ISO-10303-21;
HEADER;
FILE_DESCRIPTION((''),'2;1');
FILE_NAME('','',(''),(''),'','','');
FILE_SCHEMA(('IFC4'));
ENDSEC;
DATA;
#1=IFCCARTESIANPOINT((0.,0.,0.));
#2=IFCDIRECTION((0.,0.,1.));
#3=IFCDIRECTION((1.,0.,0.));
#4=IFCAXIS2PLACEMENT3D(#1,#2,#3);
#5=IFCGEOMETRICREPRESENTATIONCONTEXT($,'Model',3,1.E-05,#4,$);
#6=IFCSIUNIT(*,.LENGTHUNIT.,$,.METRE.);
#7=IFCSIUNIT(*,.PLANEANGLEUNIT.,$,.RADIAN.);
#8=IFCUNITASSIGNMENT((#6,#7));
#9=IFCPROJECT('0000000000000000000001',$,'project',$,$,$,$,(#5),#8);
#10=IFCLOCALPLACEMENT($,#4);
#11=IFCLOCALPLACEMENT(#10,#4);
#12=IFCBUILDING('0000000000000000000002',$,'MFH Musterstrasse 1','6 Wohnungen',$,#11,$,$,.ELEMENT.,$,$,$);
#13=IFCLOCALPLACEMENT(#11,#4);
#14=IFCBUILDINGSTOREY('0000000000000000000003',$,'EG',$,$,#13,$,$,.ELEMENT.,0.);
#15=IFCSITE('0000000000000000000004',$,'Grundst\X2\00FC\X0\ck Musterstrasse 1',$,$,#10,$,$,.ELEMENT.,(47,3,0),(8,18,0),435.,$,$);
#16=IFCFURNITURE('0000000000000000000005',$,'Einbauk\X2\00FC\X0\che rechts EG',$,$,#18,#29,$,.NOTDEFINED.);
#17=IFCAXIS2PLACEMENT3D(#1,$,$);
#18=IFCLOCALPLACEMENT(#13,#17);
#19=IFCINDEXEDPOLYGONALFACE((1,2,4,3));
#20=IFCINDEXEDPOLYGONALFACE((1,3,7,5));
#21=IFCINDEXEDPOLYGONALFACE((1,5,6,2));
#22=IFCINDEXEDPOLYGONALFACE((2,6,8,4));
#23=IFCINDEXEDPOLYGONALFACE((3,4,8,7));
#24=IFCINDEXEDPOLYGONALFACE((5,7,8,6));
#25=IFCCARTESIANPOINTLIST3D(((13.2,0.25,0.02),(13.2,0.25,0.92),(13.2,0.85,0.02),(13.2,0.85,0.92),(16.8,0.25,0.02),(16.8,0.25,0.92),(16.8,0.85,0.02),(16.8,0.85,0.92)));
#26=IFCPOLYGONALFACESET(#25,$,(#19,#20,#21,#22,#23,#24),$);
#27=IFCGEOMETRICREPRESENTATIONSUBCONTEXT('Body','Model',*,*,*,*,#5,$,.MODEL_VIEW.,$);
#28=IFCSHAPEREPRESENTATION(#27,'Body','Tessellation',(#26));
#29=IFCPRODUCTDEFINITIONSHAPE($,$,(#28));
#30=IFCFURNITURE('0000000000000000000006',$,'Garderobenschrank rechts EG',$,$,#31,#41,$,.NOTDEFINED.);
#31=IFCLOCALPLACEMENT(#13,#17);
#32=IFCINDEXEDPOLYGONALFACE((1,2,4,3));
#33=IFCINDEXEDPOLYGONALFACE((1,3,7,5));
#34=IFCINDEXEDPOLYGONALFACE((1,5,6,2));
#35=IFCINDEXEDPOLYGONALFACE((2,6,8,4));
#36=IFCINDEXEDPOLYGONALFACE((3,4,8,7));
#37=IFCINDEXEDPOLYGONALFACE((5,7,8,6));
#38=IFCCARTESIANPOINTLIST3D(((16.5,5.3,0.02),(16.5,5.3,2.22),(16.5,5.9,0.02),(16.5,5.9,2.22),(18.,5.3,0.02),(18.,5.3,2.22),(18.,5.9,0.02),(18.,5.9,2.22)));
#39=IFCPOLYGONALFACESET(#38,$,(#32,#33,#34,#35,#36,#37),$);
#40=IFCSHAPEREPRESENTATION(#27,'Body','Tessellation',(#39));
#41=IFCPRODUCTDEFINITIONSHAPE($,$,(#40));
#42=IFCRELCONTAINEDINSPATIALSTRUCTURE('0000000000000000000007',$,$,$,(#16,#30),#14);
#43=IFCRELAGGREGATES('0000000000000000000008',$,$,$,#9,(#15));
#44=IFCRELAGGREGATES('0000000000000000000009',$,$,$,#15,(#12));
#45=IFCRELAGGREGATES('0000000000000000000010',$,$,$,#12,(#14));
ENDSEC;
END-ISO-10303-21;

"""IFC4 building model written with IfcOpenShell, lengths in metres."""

from ifc_helpers import new_model, si_unit, frame, frame_2d, origin_with_axes, place, context, subcontext, project, spatial, rectangle, extrude, element, save


model = new_model("IFC4")

# Units and contexts
model_context = context("Model", 3, precision=1e-05, world=origin_with_axes())
body_context = subcontext(model_context, "Body", "Model", "MODEL_VIEW")
ifc_project = project(units=[si_unit("LENGTHUNIT", "METRE"), si_unit("PLANEANGLEUNIT", "RADIAN")], contexts=[model_context])

# Site, building, storey
site_placement = place(None, origin_with_axes())
site = spatial("IfcSite", under=ifc_project, at=site_placement, Name="Grundstück Musterstrasse 1", CompositionType="ELEMENT", RefLatitude=(47, 3, 0), RefLongitude=(8, 18, 0), RefElevation=435.0)
building_placement = place(site_placement, origin_with_axes())
building = spatial("IfcBuilding", under=site, at=building_placement, Name="MFH Musterstrasse 1", Description="6 Wohnungen", CompositionType="ELEMENT")
storey_placement = place(building_placement, origin_with_axes())
storey = spatial("IfcBuildingStorey", under=building, at=storey_placement, Name="EG", CompositionType="ELEMENT", Elevation=0.0)

# Furniture
furniture_1_placement = place(storey_placement, origin_with_axes())
element("IfcFurniture", 1, at=furniture_1_placement, inside=storey, Name="Einbauküche rechts EG", PredefinedType="NOTDEFINED", context=body_context, shape_type="SweptSolid", body=[
    extrude(rectangle(XDim=3.6, YDim=0.6, at=frame_2d((1.8, 0.3), x_axis=(1.0, 0.0))), frame((13.2, 0.25, 0.02), z_axis=(0.0, 0.0, 1.0), x_axis=(1.0, 0.0, 0.0)), (0.0, 0.0, 1.0), 0.9),
])
furniture_2_placement = place(storey_placement, origin_with_axes())
element("IfcFurniture", 2, at=furniture_2_placement, inside=storey, Name="Garderobenschrank rechts EG", PredefinedType="NOTDEFINED", context=body_context, shape_type="SweptSolid", body=[
    extrude(rectangle(XDim=1.5, YDim=0.6, at=frame_2d((0.75, 0.3), x_axis=(1.0, 0.0))), frame((16.5, 5.3, 0.02), z_axis=(0.0, 0.0, 1.0), x_axis=(1.0, 0.0, 0.0)), (0.0, 0.0, 1.0), 2.2),
])

save(model, "model.ifc")
